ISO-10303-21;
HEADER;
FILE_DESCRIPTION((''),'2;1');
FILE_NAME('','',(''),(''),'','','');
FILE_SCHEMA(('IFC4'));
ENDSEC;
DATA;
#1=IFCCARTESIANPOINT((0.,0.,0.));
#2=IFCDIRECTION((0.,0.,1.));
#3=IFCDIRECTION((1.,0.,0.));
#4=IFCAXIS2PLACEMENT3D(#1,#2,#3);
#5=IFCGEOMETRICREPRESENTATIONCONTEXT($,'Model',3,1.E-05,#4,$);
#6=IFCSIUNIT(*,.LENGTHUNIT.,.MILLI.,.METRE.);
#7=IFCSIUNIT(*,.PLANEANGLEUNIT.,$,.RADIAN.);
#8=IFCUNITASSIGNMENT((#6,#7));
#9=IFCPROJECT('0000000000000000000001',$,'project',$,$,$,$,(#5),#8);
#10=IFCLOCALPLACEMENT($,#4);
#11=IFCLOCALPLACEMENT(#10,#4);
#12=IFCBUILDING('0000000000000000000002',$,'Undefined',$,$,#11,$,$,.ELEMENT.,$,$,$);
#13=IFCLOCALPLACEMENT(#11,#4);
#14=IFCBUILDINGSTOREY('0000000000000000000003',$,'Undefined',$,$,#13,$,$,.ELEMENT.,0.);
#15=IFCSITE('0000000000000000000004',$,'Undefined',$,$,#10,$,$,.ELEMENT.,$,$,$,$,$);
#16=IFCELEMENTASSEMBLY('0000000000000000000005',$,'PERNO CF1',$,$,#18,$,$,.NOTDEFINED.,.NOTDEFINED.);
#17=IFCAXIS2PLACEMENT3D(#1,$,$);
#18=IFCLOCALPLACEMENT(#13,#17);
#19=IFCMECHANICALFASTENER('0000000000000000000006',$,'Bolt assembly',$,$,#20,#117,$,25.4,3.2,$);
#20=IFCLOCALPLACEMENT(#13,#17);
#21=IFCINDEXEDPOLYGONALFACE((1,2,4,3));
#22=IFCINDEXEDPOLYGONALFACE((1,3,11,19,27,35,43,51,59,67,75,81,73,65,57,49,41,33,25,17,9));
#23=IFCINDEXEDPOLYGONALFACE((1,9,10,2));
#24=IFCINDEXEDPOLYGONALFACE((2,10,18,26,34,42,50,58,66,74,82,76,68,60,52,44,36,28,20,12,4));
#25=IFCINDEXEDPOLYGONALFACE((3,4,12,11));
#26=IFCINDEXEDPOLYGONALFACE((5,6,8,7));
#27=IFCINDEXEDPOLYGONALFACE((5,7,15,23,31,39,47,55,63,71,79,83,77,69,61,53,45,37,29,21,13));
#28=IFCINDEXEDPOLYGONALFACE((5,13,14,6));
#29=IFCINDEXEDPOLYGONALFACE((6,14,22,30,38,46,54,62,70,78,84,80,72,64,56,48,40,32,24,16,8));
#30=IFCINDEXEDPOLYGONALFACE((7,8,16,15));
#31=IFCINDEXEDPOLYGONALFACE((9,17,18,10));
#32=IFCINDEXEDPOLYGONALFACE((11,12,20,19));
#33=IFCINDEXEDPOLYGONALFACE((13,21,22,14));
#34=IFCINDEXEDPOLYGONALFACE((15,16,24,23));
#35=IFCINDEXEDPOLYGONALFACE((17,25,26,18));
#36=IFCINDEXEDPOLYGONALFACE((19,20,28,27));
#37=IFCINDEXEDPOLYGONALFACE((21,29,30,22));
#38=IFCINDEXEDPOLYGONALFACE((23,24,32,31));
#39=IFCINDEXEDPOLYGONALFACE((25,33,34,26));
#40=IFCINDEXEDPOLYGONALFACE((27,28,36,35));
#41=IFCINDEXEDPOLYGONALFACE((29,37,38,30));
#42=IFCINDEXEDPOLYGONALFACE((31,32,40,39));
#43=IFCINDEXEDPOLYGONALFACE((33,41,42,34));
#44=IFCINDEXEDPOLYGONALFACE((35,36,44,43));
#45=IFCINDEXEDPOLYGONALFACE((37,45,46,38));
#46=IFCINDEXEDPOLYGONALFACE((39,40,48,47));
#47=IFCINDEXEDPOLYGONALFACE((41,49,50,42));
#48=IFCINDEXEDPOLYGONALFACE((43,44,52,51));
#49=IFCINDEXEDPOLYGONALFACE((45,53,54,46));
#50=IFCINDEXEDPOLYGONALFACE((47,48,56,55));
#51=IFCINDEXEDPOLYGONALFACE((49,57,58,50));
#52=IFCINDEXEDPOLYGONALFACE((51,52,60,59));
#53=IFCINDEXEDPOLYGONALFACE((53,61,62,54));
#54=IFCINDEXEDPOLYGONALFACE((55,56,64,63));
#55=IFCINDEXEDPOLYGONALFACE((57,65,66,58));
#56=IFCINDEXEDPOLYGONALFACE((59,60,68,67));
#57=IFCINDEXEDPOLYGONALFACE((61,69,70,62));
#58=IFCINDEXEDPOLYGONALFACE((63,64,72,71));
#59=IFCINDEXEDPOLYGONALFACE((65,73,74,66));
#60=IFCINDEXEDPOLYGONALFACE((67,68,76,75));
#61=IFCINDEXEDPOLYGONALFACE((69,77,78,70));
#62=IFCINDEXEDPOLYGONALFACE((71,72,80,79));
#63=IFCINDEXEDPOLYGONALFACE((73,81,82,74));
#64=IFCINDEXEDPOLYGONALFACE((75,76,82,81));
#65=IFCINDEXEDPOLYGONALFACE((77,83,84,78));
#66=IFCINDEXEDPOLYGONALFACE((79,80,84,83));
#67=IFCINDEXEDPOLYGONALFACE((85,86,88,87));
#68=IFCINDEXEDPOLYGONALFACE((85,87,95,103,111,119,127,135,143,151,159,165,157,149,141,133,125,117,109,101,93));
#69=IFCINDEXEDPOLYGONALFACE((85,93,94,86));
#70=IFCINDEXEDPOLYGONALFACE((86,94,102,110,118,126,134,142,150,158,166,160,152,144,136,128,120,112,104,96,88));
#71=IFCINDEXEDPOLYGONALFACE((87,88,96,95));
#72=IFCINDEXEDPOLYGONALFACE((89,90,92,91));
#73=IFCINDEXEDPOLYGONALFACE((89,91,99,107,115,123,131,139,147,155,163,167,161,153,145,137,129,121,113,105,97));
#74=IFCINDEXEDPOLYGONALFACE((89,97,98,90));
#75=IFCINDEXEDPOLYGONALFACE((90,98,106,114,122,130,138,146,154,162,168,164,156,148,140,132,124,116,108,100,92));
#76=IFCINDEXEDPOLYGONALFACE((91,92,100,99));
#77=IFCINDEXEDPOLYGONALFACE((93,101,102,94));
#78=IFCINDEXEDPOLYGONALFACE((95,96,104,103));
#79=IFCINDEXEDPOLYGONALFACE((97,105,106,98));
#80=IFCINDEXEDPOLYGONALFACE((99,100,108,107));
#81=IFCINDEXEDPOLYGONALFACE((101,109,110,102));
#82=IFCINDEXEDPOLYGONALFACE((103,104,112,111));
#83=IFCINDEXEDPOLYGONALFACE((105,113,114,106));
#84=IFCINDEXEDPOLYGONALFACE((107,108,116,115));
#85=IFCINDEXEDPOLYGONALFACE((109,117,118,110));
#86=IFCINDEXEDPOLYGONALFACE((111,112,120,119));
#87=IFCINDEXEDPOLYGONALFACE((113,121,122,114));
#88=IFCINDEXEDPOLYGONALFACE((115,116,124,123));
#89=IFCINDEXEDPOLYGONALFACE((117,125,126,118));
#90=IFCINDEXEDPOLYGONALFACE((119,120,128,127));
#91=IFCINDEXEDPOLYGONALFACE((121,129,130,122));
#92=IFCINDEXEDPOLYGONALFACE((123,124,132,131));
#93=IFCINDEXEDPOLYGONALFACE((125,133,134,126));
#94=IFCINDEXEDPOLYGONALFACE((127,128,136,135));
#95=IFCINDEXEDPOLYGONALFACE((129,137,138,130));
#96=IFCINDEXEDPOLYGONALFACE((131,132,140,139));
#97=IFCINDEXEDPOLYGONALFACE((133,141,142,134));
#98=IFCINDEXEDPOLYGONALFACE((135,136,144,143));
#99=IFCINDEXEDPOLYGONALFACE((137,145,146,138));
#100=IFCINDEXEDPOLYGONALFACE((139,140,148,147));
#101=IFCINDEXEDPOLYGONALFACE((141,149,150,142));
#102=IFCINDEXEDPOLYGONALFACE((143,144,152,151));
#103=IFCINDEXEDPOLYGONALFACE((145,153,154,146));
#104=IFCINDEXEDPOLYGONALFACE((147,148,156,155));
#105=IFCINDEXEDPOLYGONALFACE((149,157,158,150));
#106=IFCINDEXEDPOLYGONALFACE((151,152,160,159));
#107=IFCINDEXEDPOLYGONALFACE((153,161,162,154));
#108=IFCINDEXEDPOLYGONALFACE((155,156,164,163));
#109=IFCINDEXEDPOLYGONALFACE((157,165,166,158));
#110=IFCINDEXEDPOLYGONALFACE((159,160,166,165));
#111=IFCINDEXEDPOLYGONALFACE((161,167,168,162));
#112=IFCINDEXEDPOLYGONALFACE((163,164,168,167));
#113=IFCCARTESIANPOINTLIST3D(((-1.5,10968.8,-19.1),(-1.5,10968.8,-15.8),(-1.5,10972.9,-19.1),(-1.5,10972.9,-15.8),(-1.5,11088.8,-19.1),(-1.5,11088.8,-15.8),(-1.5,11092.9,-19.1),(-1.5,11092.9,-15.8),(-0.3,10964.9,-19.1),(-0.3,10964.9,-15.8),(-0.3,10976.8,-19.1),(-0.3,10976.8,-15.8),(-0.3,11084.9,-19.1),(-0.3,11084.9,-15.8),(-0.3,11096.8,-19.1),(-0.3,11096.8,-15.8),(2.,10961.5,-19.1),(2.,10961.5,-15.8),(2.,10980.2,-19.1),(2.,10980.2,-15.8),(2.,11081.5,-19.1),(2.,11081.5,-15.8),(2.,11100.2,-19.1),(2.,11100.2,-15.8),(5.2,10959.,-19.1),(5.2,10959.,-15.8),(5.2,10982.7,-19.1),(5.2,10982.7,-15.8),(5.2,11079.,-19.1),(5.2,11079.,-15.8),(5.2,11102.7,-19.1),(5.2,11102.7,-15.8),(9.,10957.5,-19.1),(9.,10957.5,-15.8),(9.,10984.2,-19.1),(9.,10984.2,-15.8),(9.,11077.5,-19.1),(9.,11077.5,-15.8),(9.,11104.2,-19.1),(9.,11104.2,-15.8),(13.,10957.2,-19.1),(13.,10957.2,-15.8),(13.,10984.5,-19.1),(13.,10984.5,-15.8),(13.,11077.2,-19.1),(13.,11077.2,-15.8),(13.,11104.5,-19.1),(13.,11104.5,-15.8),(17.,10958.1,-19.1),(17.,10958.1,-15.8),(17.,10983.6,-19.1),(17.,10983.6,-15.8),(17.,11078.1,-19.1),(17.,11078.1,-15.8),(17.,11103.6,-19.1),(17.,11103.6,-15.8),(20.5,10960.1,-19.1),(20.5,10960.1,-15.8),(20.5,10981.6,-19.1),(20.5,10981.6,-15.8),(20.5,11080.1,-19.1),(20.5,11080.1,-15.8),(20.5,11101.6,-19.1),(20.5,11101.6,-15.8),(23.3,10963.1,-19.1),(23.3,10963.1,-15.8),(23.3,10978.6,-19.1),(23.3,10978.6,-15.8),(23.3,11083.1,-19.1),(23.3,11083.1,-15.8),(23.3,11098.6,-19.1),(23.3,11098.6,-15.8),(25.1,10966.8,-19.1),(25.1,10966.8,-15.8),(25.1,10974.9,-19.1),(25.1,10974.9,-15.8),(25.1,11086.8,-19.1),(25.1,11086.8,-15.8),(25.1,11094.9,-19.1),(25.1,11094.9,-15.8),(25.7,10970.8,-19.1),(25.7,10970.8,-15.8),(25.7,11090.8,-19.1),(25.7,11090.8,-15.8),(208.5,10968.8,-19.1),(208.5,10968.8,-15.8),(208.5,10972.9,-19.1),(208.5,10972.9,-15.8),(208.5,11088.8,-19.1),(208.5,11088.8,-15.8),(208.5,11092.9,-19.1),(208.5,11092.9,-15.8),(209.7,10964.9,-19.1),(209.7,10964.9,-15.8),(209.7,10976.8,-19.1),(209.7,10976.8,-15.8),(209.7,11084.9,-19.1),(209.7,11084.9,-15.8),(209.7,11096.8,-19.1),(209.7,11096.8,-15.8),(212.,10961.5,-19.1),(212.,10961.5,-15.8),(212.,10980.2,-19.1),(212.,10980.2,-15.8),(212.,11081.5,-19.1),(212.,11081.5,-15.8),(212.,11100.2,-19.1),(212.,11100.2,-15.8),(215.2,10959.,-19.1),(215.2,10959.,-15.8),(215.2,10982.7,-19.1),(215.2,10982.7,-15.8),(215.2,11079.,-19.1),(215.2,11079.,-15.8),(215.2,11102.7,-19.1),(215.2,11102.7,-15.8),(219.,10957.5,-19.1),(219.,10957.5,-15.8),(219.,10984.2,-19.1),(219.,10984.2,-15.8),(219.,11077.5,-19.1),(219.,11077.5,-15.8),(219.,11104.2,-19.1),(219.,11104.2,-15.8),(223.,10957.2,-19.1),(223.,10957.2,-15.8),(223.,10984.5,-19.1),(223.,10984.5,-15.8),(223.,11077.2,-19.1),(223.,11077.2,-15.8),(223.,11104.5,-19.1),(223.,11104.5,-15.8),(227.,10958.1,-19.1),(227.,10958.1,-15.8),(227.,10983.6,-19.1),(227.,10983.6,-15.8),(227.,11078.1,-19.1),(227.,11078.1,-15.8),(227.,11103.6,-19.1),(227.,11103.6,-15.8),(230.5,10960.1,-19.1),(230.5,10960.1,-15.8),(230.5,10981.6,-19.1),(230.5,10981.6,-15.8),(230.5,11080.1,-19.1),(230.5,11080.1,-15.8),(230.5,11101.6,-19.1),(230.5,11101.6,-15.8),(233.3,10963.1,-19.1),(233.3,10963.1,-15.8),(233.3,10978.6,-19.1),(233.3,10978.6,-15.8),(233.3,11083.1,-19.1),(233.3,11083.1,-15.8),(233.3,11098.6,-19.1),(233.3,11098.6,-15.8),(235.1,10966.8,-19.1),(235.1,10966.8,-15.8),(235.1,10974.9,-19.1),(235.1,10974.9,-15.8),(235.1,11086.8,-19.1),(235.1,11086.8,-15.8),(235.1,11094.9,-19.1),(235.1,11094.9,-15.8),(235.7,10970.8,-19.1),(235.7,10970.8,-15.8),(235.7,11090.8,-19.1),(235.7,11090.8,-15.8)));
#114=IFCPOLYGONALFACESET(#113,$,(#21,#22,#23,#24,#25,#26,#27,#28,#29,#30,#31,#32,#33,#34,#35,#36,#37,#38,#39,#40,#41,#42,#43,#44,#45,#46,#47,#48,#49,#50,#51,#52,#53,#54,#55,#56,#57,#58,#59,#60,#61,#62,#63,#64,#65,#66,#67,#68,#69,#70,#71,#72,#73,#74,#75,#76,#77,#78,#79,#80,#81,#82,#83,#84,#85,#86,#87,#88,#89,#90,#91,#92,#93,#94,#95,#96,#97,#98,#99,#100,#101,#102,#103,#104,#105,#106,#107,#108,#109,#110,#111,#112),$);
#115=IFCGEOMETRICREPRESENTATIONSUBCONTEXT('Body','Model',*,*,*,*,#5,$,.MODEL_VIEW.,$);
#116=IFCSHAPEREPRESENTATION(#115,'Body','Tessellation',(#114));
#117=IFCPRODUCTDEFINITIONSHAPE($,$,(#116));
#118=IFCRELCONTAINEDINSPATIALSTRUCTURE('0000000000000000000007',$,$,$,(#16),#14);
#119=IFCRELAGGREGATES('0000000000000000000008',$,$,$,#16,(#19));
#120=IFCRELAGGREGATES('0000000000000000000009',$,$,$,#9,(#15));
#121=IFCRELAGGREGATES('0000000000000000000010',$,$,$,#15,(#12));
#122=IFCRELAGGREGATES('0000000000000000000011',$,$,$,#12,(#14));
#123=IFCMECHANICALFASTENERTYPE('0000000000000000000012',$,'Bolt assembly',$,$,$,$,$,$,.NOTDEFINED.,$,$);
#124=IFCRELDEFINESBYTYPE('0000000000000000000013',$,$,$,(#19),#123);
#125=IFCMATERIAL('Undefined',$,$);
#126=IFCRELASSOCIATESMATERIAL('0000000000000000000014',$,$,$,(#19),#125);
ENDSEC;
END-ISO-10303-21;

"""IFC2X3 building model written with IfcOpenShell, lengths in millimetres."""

from ifc_helpers import new_model, si_unit, frame, origin_with_axes, origin_2d_with_axis, place, context, subcontext, project, spatial, circle, extrude, source, transform, mapped, material, type_object, element, aggregate, save


model = new_model("IFC2X3")

# Units and contexts
model_context = context("Model", 3, precision=1e-05, world=origin_with_axes())
body_context = subcontext(model_context, "Body", "Model", "MODEL_VIEW")
ifc_project = project(units=[si_unit("LENGTHUNIT", "METRE", prefix="MILLI"), si_unit("PLANEANGLEUNIT", "RADIAN")], contexts=[model_context])

# Site, building, storey
site_placement = place(None, origin_with_axes())
site = spatial("IfcSite", under=ifc_project, at=site_placement, Name="Undefined", CompositionType="ELEMENT")
building_placement = place(site_placement, origin_with_axes())
building = spatial("IfcBuilding", under=site, at=building_placement, Name="Undefined", CompositionType="ELEMENT")
storey_placement = place(building_placement, origin_with_axes())
storey = spatial("IfcBuildingStorey", under=building, at=storey_placement, Name="Undefined", CompositionType="ELEMENT", Elevation=0.0)

# Element assembly
assembly_1_placement = place(storey_placement, origin_with_axes())
assembly_1 = element("IfcElementAssembly", 1, at=assembly_1_placement, inside=storey, Name="PERNO CF1", AssemblyPlace="NOTDEFINED", PredefinedType="NOTDEFINED")

# Shared definitions
ifc_material_1 = material(Name="Undefined")
mechanical_fastener_type = type_object("IfcMechanicalFastenerType", Name="Bolt assembly")

# Mechanical fastener
shared_shape_1 = source(origin_with_axes(), body_context, "Body", "SweptSolid", [
    extrude(circle(Radius=13.7, at=origin_2d_with_axis()), frame((0.0, 0.0, 0.0), z_axis=(0.0, 1.0, 0.0), x_axis=(1.0, 0.0, 0.0)), (0.0, 0.0, 1.0), 3.3),
])
mechanical_fastener_1_placement = place(assembly_1_placement, frame((12.0, 11030.8, -15.8), z_axis=(0.0, 1.0, 0.0), x_axis=(1.0, 0.0, 0.0)))
mechanical_fastener_1 = element("IfcMechanicalFastener", 2, at=mechanical_fastener_1_placement, type_object=mechanical_fastener_type, material=ifc_material_1, Name="Bolt assembly", NominalDiameter=25.4, NominalLength=3.2, context=body_context, shape_type="MappedRepresentation", body=[
    mapped(shared_shape_1, transform((0.0, 0.0, -60.0))),
    mapped(shared_shape_1, transform((210.0, 0.0, -60.0))),
    mapped(shared_shape_1, transform((0.0, 0.0, 60.0))),
    mapped(shared_shape_1, transform((210.0, 0.0, 60.0))),
])
aggregate(assembly_1, [mechanical_fastener_1])

save(model, "model.ifc")
